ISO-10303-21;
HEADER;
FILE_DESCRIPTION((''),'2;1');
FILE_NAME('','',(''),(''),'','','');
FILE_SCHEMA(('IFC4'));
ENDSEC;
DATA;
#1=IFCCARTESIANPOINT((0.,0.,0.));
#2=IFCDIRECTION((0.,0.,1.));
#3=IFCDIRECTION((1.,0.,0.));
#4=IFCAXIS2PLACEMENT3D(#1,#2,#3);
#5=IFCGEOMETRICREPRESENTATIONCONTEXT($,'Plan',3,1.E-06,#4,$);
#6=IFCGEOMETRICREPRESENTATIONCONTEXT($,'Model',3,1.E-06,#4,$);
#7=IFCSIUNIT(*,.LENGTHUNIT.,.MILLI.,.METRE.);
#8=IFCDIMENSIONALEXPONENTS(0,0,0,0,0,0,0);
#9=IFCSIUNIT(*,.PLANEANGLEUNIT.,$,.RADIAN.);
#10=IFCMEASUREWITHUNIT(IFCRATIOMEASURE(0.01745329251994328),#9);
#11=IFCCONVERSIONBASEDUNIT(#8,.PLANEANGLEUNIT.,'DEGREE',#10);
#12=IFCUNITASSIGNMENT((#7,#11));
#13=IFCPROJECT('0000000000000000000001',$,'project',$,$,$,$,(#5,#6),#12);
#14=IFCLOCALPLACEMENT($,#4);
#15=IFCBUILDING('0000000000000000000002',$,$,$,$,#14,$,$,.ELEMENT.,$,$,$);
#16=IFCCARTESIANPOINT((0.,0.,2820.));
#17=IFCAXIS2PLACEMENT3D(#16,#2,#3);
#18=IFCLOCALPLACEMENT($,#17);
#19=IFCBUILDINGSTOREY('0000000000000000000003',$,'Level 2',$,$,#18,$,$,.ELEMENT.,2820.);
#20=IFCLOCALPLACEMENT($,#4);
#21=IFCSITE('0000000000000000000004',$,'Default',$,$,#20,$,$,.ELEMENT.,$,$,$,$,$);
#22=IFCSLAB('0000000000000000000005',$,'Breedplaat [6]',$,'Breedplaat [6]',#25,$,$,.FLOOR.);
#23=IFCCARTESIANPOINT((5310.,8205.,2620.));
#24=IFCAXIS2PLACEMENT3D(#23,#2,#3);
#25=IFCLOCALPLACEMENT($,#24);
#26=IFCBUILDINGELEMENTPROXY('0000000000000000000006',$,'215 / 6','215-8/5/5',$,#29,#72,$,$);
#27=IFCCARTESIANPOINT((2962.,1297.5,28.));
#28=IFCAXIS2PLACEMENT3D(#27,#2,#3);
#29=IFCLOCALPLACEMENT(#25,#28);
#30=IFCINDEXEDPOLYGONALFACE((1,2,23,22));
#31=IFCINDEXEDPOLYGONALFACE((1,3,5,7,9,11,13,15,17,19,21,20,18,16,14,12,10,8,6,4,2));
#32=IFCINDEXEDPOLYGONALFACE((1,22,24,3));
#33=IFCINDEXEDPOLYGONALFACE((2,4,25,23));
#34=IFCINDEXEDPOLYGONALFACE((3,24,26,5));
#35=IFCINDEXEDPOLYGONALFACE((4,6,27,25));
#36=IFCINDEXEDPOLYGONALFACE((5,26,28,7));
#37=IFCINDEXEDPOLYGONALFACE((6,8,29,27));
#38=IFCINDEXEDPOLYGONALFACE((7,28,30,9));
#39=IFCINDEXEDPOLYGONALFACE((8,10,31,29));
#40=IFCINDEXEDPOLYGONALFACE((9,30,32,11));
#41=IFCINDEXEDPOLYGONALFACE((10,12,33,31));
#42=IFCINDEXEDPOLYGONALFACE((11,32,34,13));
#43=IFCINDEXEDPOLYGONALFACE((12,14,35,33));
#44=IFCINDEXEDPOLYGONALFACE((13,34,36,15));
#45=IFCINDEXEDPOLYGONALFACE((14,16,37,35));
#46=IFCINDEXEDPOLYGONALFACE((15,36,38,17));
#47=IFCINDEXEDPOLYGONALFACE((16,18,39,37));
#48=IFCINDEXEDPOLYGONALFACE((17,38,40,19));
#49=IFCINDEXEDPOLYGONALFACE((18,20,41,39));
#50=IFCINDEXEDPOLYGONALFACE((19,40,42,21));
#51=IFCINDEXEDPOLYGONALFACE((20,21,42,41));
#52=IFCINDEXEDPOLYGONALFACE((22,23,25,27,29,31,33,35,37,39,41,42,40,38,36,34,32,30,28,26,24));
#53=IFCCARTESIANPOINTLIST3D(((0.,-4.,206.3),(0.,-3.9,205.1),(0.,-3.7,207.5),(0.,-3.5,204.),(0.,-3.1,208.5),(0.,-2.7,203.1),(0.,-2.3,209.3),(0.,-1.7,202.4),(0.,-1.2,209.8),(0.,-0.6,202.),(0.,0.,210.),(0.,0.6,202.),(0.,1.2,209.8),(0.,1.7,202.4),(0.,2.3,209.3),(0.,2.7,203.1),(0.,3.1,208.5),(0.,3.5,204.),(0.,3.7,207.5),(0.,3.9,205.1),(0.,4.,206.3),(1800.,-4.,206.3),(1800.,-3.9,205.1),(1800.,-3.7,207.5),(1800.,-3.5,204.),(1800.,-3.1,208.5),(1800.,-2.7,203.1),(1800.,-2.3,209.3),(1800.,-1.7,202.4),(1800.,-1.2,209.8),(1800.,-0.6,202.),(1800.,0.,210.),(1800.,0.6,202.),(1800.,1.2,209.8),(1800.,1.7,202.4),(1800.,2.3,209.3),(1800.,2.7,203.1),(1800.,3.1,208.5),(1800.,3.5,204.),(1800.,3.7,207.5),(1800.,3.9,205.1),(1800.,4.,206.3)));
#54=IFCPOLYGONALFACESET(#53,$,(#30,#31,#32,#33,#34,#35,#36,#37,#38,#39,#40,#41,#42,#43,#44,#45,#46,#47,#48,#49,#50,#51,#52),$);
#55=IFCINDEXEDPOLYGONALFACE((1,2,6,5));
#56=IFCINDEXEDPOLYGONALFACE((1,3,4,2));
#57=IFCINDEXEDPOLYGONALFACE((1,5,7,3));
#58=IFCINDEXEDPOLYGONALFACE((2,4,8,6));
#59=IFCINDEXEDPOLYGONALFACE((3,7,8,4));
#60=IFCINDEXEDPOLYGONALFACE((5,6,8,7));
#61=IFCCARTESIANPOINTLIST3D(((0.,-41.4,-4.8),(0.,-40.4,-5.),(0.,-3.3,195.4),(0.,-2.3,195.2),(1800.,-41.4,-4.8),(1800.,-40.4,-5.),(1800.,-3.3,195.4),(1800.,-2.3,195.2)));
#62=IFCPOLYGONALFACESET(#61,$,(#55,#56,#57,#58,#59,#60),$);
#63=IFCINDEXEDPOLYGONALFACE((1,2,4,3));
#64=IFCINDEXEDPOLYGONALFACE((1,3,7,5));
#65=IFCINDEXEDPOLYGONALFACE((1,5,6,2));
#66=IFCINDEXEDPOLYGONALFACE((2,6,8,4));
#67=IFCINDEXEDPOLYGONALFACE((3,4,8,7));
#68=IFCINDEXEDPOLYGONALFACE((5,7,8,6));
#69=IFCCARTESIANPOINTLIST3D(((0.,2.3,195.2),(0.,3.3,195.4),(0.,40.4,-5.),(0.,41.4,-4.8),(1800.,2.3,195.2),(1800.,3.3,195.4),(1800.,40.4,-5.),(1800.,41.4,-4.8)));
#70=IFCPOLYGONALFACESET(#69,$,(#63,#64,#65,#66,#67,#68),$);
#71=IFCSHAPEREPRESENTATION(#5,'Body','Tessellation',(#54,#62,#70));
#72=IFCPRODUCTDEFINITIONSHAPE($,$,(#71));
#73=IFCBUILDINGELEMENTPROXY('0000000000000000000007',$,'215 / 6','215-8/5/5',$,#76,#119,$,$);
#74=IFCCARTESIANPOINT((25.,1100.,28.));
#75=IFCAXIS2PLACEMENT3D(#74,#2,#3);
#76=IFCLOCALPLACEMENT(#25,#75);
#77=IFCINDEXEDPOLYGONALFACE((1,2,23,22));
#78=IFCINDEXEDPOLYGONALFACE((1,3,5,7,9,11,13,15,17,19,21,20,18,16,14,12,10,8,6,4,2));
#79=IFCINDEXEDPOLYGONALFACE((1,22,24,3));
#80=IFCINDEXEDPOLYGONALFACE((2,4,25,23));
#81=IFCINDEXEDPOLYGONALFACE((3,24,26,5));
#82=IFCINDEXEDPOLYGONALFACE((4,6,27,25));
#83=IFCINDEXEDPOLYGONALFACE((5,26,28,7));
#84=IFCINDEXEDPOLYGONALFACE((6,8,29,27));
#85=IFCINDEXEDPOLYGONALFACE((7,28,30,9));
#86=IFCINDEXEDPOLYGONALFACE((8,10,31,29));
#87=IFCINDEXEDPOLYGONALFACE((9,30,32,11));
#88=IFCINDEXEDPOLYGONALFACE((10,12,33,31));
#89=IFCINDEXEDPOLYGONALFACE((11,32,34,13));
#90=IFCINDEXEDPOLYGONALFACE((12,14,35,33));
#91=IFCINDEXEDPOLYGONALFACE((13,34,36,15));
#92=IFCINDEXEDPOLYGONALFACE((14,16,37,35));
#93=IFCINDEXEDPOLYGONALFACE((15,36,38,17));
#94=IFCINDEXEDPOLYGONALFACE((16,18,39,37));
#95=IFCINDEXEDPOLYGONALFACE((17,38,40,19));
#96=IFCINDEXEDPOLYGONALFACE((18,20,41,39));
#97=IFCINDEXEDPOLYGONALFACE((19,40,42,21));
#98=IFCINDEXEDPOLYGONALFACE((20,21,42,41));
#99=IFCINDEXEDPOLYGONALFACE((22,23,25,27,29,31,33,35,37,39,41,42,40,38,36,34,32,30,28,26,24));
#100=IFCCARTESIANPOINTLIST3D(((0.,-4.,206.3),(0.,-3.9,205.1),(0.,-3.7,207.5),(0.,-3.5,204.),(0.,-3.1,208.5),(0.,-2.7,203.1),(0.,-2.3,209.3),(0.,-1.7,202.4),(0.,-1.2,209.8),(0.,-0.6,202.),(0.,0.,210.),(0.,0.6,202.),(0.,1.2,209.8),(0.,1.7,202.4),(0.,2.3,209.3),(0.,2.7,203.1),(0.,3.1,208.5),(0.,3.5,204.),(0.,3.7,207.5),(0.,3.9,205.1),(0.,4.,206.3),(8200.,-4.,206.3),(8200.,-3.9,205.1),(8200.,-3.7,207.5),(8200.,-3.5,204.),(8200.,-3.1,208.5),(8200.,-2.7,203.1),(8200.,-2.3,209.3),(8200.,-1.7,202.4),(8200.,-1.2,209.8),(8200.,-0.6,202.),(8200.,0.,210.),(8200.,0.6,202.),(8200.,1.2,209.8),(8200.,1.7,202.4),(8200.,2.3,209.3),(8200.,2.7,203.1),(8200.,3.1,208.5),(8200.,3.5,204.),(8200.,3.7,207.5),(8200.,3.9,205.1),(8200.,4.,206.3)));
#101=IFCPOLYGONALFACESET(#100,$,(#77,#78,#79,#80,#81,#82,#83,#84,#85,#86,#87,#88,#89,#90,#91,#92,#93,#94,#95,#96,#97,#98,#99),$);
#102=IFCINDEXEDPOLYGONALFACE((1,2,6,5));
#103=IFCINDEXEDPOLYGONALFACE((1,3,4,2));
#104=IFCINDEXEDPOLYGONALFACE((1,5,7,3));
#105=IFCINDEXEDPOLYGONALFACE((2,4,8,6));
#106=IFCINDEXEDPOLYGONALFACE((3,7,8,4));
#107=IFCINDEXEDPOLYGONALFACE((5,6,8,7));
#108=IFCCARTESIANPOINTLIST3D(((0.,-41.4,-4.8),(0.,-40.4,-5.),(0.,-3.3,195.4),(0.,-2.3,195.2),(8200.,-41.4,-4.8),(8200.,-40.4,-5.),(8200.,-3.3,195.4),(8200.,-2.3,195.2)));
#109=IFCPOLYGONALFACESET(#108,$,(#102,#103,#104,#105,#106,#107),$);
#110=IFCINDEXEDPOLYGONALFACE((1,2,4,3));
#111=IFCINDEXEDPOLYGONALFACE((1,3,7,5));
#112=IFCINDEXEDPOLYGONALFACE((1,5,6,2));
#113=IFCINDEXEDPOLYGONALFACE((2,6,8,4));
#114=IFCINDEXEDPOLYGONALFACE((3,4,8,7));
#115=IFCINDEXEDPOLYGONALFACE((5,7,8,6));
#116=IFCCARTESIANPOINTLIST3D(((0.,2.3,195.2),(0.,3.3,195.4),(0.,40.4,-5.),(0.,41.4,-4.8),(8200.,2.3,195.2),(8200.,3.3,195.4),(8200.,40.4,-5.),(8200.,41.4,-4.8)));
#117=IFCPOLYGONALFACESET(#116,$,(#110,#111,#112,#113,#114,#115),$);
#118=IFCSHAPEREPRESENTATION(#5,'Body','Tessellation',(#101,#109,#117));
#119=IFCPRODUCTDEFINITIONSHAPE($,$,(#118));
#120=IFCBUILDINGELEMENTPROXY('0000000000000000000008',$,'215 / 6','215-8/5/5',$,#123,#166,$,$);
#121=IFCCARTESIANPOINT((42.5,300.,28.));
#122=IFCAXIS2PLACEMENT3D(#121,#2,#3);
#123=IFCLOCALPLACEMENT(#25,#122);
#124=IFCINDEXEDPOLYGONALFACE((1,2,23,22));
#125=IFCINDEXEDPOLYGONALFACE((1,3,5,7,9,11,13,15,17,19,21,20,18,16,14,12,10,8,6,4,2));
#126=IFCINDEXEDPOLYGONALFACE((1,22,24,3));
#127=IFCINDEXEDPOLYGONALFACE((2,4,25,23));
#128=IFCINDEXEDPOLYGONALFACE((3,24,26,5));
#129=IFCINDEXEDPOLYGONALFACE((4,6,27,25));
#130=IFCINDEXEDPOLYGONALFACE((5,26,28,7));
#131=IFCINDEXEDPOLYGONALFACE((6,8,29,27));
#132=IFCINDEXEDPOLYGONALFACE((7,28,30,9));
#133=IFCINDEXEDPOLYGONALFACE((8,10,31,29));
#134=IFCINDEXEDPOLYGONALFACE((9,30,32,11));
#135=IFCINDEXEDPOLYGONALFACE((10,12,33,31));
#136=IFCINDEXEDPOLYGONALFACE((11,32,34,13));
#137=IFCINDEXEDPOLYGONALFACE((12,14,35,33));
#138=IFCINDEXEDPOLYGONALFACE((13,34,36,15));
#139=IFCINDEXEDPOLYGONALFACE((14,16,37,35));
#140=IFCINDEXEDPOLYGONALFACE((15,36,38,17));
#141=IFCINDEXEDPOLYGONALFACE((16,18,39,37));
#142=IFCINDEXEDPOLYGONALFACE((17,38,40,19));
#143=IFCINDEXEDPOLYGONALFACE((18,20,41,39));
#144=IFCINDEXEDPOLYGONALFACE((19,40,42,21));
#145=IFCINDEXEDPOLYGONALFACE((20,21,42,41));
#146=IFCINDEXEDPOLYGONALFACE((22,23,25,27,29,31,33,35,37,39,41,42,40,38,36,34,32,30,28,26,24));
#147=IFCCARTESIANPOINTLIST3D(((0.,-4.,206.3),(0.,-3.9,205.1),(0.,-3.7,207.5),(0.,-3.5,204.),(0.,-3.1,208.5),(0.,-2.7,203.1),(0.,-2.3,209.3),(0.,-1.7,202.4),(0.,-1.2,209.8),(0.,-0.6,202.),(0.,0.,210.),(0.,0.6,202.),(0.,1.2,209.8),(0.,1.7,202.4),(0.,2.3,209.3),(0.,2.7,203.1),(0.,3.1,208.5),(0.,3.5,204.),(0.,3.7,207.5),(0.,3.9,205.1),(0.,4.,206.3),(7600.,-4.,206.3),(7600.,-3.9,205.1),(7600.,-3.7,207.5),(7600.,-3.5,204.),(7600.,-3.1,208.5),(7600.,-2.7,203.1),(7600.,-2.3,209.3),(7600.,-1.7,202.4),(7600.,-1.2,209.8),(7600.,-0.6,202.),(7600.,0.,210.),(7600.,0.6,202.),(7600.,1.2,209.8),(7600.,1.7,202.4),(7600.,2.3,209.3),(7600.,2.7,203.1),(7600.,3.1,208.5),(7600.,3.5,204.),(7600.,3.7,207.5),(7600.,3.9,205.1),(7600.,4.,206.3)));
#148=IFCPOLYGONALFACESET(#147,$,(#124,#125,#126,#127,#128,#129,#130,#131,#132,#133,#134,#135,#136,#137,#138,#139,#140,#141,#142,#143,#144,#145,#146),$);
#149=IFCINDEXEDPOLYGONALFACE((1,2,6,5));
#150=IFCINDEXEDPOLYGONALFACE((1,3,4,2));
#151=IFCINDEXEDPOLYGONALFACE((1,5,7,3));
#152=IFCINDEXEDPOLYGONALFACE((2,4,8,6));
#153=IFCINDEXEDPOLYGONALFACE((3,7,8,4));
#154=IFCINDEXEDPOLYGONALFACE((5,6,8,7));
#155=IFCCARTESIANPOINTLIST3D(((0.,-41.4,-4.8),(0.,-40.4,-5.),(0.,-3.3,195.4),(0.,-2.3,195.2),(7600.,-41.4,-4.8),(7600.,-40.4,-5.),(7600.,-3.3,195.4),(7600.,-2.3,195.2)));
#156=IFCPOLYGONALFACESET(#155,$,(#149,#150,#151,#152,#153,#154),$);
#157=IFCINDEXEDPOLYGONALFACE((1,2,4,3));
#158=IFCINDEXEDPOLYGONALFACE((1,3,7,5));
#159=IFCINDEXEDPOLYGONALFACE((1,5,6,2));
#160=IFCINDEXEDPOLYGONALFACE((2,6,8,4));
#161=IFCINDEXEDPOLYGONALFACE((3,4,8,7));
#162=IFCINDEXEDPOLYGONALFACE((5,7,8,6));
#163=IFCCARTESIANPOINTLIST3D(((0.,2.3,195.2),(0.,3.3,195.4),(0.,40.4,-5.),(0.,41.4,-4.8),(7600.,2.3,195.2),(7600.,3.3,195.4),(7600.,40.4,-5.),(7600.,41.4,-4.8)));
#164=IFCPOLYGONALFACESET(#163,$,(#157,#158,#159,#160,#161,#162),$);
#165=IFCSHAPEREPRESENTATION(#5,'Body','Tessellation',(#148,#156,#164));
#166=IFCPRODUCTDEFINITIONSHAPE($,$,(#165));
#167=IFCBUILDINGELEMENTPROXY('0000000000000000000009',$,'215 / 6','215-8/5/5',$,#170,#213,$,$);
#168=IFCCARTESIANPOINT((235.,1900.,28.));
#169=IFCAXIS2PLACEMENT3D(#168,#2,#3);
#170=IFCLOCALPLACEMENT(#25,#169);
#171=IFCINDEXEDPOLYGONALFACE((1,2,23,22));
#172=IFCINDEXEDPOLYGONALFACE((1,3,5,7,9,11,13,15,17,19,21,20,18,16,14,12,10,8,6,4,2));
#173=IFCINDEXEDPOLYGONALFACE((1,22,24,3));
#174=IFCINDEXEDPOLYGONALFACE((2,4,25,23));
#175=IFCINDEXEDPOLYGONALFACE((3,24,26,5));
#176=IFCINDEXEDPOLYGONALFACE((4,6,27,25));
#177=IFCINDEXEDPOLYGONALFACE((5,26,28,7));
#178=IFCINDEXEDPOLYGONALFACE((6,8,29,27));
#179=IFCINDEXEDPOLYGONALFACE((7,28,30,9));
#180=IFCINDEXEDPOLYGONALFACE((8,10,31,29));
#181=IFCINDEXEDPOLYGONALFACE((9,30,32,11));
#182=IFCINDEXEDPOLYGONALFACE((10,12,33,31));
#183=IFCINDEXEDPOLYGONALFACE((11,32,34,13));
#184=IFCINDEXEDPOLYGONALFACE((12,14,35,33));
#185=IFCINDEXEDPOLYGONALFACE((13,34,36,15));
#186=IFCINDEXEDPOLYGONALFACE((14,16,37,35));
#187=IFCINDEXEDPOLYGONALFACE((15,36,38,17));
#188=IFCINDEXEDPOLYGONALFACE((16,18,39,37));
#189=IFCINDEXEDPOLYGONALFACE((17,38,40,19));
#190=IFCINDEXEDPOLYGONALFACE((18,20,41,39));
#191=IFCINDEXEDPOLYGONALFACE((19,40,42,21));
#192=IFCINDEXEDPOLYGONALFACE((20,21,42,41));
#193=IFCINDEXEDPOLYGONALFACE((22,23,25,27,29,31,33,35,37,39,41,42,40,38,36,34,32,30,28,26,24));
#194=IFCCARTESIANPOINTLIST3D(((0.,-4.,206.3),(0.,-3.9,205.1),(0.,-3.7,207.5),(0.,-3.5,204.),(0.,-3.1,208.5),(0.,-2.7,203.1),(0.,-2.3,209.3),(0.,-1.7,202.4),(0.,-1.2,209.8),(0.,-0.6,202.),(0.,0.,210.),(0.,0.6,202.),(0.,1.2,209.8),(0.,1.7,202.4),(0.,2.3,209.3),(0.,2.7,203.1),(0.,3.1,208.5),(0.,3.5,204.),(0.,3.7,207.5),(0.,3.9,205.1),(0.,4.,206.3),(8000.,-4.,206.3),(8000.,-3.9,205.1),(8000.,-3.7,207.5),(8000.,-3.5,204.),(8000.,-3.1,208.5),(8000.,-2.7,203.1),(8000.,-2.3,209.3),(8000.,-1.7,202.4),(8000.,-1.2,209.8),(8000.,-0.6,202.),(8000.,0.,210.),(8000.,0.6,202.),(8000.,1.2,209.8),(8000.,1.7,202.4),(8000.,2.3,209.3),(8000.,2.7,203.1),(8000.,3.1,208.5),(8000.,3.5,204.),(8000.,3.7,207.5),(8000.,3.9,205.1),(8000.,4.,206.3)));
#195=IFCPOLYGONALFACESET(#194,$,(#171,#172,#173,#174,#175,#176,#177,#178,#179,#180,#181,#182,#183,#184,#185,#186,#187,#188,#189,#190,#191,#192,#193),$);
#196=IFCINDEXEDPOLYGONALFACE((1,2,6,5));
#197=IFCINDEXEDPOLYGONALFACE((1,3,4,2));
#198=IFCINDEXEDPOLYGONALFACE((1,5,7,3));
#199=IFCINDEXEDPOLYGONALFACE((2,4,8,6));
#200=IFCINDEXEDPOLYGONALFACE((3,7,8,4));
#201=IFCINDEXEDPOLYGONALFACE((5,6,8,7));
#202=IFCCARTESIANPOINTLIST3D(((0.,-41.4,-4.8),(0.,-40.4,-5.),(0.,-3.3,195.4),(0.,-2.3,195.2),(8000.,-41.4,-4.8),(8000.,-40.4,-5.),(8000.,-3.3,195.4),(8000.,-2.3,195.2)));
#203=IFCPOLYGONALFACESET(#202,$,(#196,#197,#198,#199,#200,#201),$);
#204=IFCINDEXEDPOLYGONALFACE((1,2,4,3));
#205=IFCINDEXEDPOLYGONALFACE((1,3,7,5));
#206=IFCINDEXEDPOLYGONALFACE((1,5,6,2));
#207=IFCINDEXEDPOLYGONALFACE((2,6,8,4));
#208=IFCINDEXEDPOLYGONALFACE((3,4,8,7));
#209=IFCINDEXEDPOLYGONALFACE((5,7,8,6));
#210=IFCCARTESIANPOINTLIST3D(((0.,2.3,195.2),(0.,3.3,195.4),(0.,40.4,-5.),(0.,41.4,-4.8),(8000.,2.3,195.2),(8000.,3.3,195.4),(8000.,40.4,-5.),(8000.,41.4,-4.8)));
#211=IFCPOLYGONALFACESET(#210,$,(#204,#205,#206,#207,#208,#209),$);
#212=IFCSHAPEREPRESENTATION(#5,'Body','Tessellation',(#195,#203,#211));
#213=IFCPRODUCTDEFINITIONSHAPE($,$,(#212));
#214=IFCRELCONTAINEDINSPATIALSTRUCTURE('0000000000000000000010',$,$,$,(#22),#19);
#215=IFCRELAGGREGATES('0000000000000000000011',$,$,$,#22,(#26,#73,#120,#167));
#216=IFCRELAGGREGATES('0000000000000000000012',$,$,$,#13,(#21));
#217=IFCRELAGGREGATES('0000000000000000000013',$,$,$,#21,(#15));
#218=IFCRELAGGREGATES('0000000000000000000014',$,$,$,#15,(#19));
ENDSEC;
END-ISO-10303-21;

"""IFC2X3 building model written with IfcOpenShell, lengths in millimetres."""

from ifc_helpers import new_model, entity, si_unit, converted_unit, frame, origin_with_axes, origin_2d_with_axis, place, context, project, spatial, rectangle, circle, extrude, element, aggregate, save


model = new_model("IFC2X3")

# Units and contexts
plan_context = context("Plan", 3, precision=1e-06, world=origin_with_axes())
model_context = context("Model", 3, precision=1e-06, world=origin_with_axes())
ifc_project = project(units=[si_unit("LENGTHUNIT", "METRE", prefix="MILLI"), converted_unit("PLANEANGLEUNIT", "DEGREE", entity("IfcRatioMeasure", 0.01745329251994328), si_unit("PLANEANGLEUNIT", "RADIAN"), dimensions=[0, 0, 0, 0, 0, 0, 0])], contexts=[plan_context, model_context])

# Site, building, storey
site_placement = place(None, origin_with_axes())
site = spatial("IfcSite", under=ifc_project, at=site_placement, Name="Default", CompositionType="ELEMENT")
building_placement = place(None, origin_with_axes())
building = spatial("IfcBuilding", under=site, at=building_placement, CompositionType="ELEMENT")
storey_placement = place(None, frame((0.0, 0.0, 2820.0), z_axis=(0.0, 0.0, 1.0), x_axis=(1.0, 0.0, 0.0)))
storey = spatial("IfcBuildingStorey", under=building, at=storey_placement, Name="Level 2", CompositionType="ELEMENT", Elevation=2820.0)

# Slab, building element proxies
slab_1_placement = place(None, frame((5310.0, 8205.0, 2620.0), z_axis=(0.0, 0.0, 1.0), x_axis=(1.0, 0.0, 0.0)))
slab_1 = element("IfcSlab", 1, at=slab_1_placement, inside=storey, Name="Breedplaat [6]", ObjectType="Breedplaat [6]", PredefinedType="FLOOR")
proxy_1_placement = place(slab_1_placement, frame((2962.0, 1297.5, 28.0), z_axis=(0.0, 0.0, 1.0), x_axis=(1.0, 0.0, 0.0)))
proxy_1 = element("IfcBuildingElementProxy", 2, at=proxy_1_placement, Name="215 / 6", Description="215-8/5/5", context=plan_context, shape_type="SweptSolid", body=[
    extrude(circle(Radius=4.0, at=origin_2d_with_axis()), frame((0.0, 0.0, 206.0), z_axis=(1.0, 0.0, 0.0), x_axis=(0.0, 0.0, 1.0)), (0.0, 0.0, 1.0), 1800.0),
    extrude(rectangle(XDim=203.8, YDim=1.0, at=origin_2d_with_axis()), frame((0.0, -21.9, 95.2), z_axis=(1.0, 0.0, 0.0), x_axis=(0.0, 0.187112, 0.982339)), (0.0, 0.0, 1.0), 1800.0),
    extrude(rectangle(XDim=203.8, YDim=1.0, at=origin_2d_with_axis()), frame((0.0, 21.9, 95.2), z_axis=(1.0, 0.0, 0.0), x_axis=(0.0, -0.187112, 0.982339)), (0.0, 0.0, 1.0), 1800.0),
])
proxy_2_placement = place(slab_1_placement, frame((25.0, 1100.0, 28.0), z_axis=(0.0, 0.0, 1.0), x_axis=(1.0, 0.0, 0.0)))
proxy_2 = element("IfcBuildingElementProxy", 3, at=proxy_2_placement, Name="215 / 6", Description="215-8/5/5", context=plan_context, shape_type="SweptSolid", body=[
    extrude(circle(Radius=4.0, at=origin_2d_with_axis()), frame((0.0, 0.0, 206.0), z_axis=(1.0, 0.0, 0.0), x_axis=(0.0, 0.0, 1.0)), (0.0, 0.0, 1.0), 8200.0),
    extrude(rectangle(XDim=203.8, YDim=1.0, at=origin_2d_with_axis()), frame((0.0, -21.9, 95.2), z_axis=(1.0, 0.0, 0.0), x_axis=(0.0, 0.187112, 0.982339)), (0.0, 0.0, 1.0), 8200.0),
    extrude(rectangle(XDim=203.8, YDim=1.0, at=origin_2d_with_axis()), frame((0.0, 21.9, 95.2), z_axis=(1.0, 0.0, 0.0), x_axis=(0.0, -0.187112, 0.982339)), (0.0, 0.0, 1.0), 8200.0),
])
proxy_3_placement = place(slab_1_placement, frame((42.5, 300.0, 28.0), z_axis=(0.0, 0.0, 1.0), x_axis=(1.0, 0.0, 0.0)))
proxy_3 = element("IfcBuildingElementProxy", 4, at=proxy_3_placement, Name="215 / 6", Description="215-8/5/5", context=plan_context, shape_type="SweptSolid", body=[
    extrude(circle(Radius=4.0, at=origin_2d_with_axis()), frame((0.0, 0.0, 206.0), z_axis=(1.0, 0.0, 0.0), x_axis=(0.0, 0.0, 1.0)), (0.0, 0.0, 1.0), 7600.0),
    extrude(rectangle(XDim=203.8, YDim=1.0, at=origin_2d_with_axis()), frame((0.0, -21.9, 95.2), z_axis=(1.0, 0.0, 0.0), x_axis=(0.0, 0.187112, 0.982339)), (0.0, 0.0, 1.0), 7600.0),
    extrude(rectangle(XDim=203.8, YDim=1.0, at=origin_2d_with_axis()), frame((0.0, 21.9, 95.2), z_axis=(1.0, 0.0, 0.0), x_axis=(0.0, -0.187112, 0.982339)), (0.0, 0.0, 1.0), 7600.0),
])
proxy_4_placement = place(slab_1_placement, frame((235.0, 1900.0, 28.0), z_axis=(0.0, 0.0, 1.0), x_axis=(1.0, 0.0, 0.0)))
proxy_4 = element("IfcBuildingElementProxy", 5, at=proxy_4_placement, Name="215 / 6", Description="215-8/5/5", context=plan_context, shape_type="SweptSolid", body=[
    extrude(circle(Radius=4.0, at=origin_2d_with_axis()), frame((0.0, 0.0, 206.0), z_axis=(1.0, 0.0, 0.0), x_axis=(0.0, 0.0, 1.0)), (0.0, 0.0, 1.0), 8000.0),
    extrude(rectangle(XDim=203.8, YDim=1.0, at=origin_2d_with_axis()), frame((0.0, -21.9, 95.2), z_axis=(1.0, 0.0, 0.0), x_axis=(0.0, 0.187112, 0.982339)), (0.0, 0.0, 1.0), 8000.0),
    extrude(rectangle(XDim=203.8, YDim=1.0, at=origin_2d_with_axis()), frame((0.0, 21.9, 95.2), z_axis=(1.0, 0.0, 0.0), x_axis=(0.0, -0.187112, 0.982339)), (0.0, 0.0, 1.0), 8000.0),
])
aggregate(slab_1, [proxy_1, proxy_2, proxy_3, proxy_4])

save(model, "model.ifc")
